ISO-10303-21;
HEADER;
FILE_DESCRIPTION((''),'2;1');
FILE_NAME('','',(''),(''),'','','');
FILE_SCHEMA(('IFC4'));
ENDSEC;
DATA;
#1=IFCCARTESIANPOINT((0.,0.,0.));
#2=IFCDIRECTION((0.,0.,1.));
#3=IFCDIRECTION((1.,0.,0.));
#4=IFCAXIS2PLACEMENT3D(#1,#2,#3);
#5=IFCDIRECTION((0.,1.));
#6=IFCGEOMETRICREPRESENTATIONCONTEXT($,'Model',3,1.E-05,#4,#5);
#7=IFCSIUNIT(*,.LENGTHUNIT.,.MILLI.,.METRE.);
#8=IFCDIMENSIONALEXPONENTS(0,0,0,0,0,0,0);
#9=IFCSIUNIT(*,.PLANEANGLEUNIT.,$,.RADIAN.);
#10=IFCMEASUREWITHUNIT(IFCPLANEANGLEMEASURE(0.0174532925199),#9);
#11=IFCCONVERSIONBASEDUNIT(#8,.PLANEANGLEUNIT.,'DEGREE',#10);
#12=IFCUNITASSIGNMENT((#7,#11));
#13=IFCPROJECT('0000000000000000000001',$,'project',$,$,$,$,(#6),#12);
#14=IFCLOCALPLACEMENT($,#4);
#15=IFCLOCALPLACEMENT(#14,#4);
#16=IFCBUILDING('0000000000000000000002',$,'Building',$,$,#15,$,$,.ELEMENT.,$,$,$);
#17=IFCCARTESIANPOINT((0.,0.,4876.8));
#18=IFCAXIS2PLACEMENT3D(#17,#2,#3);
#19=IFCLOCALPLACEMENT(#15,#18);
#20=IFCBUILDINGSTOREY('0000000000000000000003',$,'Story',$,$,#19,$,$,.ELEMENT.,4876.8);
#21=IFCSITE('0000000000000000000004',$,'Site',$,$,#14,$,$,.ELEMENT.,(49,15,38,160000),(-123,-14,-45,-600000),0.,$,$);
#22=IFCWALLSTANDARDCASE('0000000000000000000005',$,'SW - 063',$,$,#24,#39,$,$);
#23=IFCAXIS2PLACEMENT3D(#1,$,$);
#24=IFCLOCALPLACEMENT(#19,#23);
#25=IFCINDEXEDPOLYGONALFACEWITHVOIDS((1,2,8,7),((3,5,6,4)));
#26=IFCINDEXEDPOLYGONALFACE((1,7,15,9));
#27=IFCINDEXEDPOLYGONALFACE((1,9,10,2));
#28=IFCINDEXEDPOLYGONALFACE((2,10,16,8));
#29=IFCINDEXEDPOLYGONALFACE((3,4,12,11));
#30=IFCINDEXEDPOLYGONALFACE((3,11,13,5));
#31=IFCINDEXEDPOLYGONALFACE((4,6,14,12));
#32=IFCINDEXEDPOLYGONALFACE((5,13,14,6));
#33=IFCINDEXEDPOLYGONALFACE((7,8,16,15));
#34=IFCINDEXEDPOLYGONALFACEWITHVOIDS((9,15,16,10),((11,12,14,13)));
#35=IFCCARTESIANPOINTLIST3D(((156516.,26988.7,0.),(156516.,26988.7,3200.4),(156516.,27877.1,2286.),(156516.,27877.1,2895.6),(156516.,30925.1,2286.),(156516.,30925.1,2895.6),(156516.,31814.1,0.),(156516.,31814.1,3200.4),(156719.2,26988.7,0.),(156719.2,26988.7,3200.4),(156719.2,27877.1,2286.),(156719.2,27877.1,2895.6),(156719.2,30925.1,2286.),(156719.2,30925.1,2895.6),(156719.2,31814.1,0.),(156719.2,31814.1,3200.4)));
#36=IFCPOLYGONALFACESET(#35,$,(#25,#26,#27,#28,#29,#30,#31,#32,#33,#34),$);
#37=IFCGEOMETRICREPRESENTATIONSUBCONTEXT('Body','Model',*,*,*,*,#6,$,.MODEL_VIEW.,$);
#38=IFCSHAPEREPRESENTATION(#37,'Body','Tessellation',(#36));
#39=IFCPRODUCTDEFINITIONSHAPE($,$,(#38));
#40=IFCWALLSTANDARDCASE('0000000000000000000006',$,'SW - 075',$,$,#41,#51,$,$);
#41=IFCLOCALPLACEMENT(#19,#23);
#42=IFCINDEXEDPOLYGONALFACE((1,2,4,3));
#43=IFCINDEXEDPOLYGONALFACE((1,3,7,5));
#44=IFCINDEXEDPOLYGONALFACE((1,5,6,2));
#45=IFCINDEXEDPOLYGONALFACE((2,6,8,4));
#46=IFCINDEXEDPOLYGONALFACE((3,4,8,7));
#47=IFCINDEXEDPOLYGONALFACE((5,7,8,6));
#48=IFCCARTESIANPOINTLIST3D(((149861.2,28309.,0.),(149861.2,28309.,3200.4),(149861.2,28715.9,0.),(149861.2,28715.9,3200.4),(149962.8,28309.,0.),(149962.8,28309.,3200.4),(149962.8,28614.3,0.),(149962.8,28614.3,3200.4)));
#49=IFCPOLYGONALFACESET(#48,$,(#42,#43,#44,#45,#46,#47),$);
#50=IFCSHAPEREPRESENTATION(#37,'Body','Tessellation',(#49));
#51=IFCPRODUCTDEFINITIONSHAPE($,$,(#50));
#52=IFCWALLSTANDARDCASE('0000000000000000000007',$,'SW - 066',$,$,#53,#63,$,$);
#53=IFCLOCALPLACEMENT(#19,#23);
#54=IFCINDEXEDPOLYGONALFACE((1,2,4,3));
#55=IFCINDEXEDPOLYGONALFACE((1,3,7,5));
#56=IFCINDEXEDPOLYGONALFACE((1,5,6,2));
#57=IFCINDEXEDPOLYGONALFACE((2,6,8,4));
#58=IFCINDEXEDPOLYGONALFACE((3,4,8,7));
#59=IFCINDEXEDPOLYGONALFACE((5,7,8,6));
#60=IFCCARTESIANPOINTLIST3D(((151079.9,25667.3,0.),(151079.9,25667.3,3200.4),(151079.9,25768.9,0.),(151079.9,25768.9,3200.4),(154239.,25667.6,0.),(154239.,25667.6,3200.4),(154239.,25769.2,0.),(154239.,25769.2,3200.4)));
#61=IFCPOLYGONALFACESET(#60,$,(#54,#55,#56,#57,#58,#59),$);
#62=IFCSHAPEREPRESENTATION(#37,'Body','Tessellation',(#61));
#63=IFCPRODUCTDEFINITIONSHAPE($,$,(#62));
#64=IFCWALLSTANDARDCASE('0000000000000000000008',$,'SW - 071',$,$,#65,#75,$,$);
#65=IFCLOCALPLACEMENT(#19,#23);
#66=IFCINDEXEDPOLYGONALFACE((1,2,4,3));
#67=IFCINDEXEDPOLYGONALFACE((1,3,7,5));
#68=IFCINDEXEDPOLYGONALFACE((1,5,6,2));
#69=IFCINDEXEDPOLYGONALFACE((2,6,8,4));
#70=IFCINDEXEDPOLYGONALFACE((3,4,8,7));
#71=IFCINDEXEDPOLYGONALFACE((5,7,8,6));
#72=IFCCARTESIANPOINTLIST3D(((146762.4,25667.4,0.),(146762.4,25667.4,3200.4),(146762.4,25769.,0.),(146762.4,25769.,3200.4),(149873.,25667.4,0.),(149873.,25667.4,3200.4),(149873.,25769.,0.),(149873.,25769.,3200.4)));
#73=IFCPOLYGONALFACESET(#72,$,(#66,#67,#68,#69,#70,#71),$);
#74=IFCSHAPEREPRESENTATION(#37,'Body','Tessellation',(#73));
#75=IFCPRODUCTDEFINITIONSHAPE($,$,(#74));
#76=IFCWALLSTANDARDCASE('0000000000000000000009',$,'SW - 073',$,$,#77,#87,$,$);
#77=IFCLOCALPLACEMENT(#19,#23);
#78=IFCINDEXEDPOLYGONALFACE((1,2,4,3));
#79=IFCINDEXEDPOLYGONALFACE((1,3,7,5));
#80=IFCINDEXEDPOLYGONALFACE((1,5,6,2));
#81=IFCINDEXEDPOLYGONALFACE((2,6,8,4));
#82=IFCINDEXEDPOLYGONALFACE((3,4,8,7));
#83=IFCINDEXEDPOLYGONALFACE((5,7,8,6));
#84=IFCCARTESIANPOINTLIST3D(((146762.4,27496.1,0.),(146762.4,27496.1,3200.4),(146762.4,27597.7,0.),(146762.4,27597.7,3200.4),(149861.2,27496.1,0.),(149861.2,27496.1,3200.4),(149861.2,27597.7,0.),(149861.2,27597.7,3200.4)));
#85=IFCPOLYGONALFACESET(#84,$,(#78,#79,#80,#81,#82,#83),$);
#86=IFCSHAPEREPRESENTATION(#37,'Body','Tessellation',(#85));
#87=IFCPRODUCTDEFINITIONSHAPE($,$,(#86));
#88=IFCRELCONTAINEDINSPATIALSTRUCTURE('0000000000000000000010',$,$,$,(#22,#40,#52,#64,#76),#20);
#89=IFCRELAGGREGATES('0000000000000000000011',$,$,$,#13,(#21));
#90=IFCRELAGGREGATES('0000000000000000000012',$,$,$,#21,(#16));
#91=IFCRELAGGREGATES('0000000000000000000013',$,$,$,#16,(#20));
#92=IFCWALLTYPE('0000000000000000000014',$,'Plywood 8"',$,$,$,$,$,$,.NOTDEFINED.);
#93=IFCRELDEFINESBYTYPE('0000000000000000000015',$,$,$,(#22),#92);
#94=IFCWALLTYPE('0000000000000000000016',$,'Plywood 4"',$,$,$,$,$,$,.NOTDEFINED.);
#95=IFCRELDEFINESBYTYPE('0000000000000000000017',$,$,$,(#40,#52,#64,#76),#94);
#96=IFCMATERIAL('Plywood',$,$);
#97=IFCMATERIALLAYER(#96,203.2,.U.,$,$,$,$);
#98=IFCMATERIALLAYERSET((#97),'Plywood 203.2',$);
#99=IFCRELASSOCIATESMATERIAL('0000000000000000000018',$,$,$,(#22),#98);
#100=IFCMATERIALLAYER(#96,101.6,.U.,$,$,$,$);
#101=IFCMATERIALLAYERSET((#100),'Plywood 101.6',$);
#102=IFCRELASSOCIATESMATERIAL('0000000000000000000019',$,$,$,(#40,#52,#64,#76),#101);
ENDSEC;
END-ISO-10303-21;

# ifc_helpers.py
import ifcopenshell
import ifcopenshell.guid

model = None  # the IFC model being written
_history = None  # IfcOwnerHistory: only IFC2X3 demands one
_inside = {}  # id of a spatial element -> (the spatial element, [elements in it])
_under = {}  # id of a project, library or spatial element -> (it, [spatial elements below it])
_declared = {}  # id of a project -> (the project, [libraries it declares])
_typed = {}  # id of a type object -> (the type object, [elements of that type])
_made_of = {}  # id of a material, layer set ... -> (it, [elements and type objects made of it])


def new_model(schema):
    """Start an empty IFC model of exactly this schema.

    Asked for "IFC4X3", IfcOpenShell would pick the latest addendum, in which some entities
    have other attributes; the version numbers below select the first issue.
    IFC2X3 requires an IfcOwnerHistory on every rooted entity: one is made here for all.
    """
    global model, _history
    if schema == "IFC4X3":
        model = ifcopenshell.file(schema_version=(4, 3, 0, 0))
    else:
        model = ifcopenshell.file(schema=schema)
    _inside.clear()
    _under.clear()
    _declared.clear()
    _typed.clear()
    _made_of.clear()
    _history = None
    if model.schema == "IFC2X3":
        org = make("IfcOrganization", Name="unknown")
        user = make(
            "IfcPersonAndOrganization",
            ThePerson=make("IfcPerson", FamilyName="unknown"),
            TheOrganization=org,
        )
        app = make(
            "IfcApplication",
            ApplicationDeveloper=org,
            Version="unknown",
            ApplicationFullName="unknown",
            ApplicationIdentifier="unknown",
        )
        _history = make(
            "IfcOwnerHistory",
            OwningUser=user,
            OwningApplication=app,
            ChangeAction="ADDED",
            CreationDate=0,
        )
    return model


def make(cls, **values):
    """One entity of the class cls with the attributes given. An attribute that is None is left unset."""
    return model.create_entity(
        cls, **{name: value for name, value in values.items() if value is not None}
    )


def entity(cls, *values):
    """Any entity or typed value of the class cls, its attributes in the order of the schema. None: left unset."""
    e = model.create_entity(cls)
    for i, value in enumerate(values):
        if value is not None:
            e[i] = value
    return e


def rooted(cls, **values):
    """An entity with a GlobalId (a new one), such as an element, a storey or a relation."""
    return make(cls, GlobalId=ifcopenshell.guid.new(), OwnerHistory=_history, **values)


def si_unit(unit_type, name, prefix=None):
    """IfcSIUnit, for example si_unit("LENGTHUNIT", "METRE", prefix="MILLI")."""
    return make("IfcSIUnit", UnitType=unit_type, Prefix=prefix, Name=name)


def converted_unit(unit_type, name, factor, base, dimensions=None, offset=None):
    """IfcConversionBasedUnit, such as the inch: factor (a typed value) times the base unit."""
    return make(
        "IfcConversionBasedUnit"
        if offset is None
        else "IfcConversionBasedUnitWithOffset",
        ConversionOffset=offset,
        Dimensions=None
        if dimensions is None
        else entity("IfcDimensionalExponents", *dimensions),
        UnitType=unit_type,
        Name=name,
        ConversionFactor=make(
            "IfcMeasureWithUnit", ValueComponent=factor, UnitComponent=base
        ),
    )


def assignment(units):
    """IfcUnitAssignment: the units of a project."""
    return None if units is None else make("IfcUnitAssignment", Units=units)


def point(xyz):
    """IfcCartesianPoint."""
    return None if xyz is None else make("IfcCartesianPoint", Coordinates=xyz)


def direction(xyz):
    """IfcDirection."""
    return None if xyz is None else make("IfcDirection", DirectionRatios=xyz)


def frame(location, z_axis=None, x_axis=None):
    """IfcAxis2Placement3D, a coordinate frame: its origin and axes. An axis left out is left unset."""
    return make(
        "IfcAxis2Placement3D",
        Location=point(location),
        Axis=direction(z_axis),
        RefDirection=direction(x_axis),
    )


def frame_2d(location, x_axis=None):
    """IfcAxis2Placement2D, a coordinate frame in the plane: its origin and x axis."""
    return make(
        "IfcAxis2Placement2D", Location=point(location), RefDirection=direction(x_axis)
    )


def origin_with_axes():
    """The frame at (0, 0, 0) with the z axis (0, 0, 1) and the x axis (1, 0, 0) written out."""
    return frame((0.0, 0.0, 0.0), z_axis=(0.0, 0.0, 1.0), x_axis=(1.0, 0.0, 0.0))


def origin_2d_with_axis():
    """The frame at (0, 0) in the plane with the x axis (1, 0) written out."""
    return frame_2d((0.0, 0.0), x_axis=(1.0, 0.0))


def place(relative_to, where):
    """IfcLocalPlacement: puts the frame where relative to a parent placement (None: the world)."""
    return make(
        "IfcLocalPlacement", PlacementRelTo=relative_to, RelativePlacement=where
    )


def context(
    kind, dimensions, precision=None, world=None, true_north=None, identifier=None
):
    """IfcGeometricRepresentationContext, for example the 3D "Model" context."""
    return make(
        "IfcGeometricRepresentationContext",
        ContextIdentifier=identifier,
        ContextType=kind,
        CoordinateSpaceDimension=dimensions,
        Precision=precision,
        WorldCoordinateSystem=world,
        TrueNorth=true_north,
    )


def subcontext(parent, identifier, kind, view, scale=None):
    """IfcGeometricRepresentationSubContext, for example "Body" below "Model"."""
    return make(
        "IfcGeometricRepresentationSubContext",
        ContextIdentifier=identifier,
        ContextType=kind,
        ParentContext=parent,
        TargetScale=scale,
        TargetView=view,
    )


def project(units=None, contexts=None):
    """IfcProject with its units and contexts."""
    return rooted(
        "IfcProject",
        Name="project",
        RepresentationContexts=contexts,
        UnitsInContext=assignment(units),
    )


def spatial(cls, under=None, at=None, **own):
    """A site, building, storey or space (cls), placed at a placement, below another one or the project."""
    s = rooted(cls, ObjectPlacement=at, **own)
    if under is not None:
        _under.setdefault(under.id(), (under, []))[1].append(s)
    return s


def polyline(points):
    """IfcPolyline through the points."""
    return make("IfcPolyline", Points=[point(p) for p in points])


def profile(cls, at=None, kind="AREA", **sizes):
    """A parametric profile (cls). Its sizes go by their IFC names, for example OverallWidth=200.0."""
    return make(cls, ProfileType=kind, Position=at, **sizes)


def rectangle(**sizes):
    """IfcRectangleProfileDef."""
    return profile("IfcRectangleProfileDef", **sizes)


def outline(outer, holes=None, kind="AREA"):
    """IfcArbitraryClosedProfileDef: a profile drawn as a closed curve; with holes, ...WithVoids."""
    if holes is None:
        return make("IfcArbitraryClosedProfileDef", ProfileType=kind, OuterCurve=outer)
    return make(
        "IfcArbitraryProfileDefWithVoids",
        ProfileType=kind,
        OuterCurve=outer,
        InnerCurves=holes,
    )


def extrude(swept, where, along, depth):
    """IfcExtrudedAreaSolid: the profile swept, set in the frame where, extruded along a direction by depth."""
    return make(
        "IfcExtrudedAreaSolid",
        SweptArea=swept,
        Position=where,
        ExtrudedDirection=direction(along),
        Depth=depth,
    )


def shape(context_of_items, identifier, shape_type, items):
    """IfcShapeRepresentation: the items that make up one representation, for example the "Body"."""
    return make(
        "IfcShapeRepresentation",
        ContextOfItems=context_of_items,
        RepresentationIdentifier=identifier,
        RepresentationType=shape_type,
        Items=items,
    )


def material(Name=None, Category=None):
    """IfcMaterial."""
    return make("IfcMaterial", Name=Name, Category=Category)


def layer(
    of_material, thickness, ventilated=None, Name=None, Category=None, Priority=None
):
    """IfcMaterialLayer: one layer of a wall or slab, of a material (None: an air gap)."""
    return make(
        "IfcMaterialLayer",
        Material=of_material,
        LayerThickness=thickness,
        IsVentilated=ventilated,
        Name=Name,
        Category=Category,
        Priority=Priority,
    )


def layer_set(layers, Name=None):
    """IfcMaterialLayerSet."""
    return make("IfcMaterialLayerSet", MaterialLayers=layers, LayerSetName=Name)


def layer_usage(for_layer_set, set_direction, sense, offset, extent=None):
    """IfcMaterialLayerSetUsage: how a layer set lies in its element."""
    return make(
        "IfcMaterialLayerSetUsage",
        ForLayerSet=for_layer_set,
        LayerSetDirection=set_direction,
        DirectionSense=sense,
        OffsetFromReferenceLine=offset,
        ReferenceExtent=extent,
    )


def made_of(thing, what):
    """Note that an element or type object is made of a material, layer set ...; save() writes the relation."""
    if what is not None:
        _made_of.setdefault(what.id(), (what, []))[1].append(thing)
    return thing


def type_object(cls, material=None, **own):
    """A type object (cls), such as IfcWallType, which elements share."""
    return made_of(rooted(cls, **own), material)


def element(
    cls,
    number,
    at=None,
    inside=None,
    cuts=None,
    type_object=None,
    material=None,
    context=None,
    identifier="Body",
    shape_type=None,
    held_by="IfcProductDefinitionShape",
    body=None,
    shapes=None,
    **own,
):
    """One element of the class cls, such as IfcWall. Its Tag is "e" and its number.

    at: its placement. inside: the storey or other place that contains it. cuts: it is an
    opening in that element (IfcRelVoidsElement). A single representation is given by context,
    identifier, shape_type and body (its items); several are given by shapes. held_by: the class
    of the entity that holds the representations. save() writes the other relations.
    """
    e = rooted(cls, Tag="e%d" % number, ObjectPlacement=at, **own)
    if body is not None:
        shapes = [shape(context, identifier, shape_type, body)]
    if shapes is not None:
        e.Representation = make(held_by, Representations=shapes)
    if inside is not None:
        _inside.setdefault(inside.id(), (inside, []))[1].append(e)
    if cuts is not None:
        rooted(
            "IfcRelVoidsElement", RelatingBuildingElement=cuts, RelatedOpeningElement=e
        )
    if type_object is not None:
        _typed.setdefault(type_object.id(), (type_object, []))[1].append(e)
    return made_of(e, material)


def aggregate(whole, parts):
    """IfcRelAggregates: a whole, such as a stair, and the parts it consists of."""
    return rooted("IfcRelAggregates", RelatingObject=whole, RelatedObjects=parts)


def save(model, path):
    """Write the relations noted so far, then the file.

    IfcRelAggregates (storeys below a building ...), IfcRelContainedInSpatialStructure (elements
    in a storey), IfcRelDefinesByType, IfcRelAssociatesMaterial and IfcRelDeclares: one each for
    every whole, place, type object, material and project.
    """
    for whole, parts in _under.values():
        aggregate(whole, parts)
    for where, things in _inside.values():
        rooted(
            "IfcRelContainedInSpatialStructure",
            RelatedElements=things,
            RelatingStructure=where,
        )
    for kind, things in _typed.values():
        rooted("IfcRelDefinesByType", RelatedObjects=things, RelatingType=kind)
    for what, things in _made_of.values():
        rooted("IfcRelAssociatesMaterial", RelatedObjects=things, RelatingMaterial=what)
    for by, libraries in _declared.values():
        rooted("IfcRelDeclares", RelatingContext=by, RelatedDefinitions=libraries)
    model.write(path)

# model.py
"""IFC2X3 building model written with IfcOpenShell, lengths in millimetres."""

from ifc_helpers import new_model, entity, si_unit, converted_unit, direction, frame, origin_with_axes, origin_2d_with_axis, place, context, subcontext, project, spatial, polyline, rectangle, outline, extrude, material, layer, layer_set, layer_usage, type_object, element, save


model = new_model("IFC2X3")

# Units and contexts
model_context = context("Model", 3, precision=1e-05, world=origin_with_axes(), true_north=direction((0.0, 1.0)))
body_context = subcontext(model_context, "Body", "Model", "MODEL_VIEW")
ifc_project = project(units=[si_unit("LENGTHUNIT", "METRE", prefix="MILLI"), converted_unit("PLANEANGLEUNIT", "DEGREE", entity("IfcPlaneAngleMeasure", 0.0174532925199), si_unit("PLANEANGLEUNIT", "RADIAN"), dimensions=[0, 0, 0, 0, 0, 0, 0])], contexts=[model_context])

# Site, building, storey
site_placement = place(None, origin_with_axes())
site = spatial("IfcSite", under=ifc_project, at=site_placement, Name="Site", CompositionType="ELEMENT", RefLatitude=(49, 15, 38, 160000), RefLongitude=(-123, -14, -45, -600000), RefElevation=0.0)
building_placement = place(site_placement, origin_with_axes())
building = spatial("IfcBuilding", under=site, at=building_placement, Name="Building", CompositionType="ELEMENT")
storey_placement = place(building_placement, frame((0.0, 0.0, 4876.8), z_axis=(0.0, 0.0, 1.0), x_axis=(1.0, 0.0, 0.0)))
storey = spatial("IfcBuildingStorey", under=building, at=storey_placement, Name="Story", CompositionType="ELEMENT", Elevation=4876.8)

# Shared definitions
ifc_material_1 = material(Name="Plywood")
ifc_layer_1 = layer(ifc_material_1, 203.2, ventilated="UNKNOWN")
ifc_layer_set_1 = layer_set([ifc_layer_1], Name="Plywood 203.2")
wall_type_1 = type_object("IfcWallType", Name="Plywood 8\"", PredefinedType="NOTDEFINED")

# Wall, opening
ifc_layer_usage_1 = layer_usage(ifc_layer_set_1, "AXIS2", "NEGATIVE", 0.0)
wall_1_placement = place(storey_placement, frame((156516.0, 26988.7, 0.0), z_axis=(0.0, 0.0, 1.0), x_axis=(0.0, 1.0, 0.0)))
wall_1 = element("IfcWallStandardCase", 1, at=wall_1_placement, inside=storey, type_object=wall_type_1, material=ifc_layer_usage_1, Name="SW - 063", context=body_context, shape_type="SweptSolid", body=[
    extrude(outline(polyline([(0.0, -203.2), (4825.5, -203.2), (4825.5, 0.0), (0.0, 0.0), (0.0, -203.2)])), origin_with_axes(), (0.0, 0.0, 1.0), 3200.4),
])
opening_1_placement = place(wall_1_placement, frame((2412.5, 0.0, 2286.0), z_axis=(0.0, 0.0, 1.0), x_axis=(1.0, 0.0, 0.0)))
element("IfcOpeningElement", 2, at=opening_1_placement, cuts=wall_1, context=body_context, shape_type="SweptSolid", body=[
    extrude(rectangle(XDim=3048.0, YDim=609.6, at=origin_2d_with_axis()), frame((0.0, 203.2, 304.8), z_axis=(0.0, 1.0, 0.0), x_axis=(1.0, 0.0, 0.0)), (0.0, 0.0, -1.0), 609.6),
])

# Wall
ifc_layer_2 = layer(ifc_material_1, 101.6, ventilated="UNKNOWN")
ifc_layer_set_2 = layer_set([ifc_layer_2], Name="Plywood 101.6")
ifc_layer_usage_2 = layer_usage(ifc_layer_set_2, "AXIS2", "NEGATIVE", 0.0)
wall_type_2 = type_object("IfcWallType", Name="Plywood 4\"", PredefinedType="NOTDEFINED")
wall_2_placement = place(storey_placement, frame((149861.2, 28309.0, 0.0), z_axis=(0.0, 0.0, 1.0), x_axis=(0.0, 1.0, 0.0)))
element("IfcWallStandardCase", 3, at=wall_2_placement, inside=storey, type_object=wall_type_2, material=ifc_layer_usage_2, Name="SW - 075", context=body_context, shape_type="SweptSolid", body=[
    extrude(outline(polyline([(0.0, -101.6), (305.3, -101.6), (406.9, 0.0), (0.0, 0.0), (0.0, -101.6)])), origin_with_axes(), (0.0, 0.0, 1.0), 3200.4),
])

# Wall
ifc_layer_usage_3 = layer_usage(ifc_layer_set_2, "AXIS2", "NEGATIVE", 0.0)
wall_3_placement = place(storey_placement, frame((151079.9, 25768.9, 0.0), z_axis=(0.0, 0.0, 1.0), x_axis=(1.0, 0.000087, 0.0)))
element("IfcWallStandardCase", 4, at=wall_3_placement, inside=storey, type_object=wall_type_2, material=ifc_layer_usage_3, Name="SW - 066", context=body_context, shape_type="SweptSolid", body=[
    extrude(outline(polyline([(0.0, -101.6), (3159.2, -101.6), (3159.2, 0.0), (0.0, 0.0), (0.0, -101.6)])), origin_with_axes(), (0.0, 0.0, 1.0), 3200.4),
])

# Walls
ifc_layer_usage_4 = layer_usage(ifc_layer_set_2, "AXIS2", "NEGATIVE", 0.0)
wall_4_placement = place(storey_placement, frame((146762.4, 25769.0, 0.0), z_axis=(0.0, 0.0, 1.0), x_axis=(1.0, 0.0, 0.0)))
element("IfcWallStandardCase", 5, at=wall_4_placement, inside=storey, type_object=wall_type_2, material=ifc_layer_usage_4, Name="SW - 071", context=body_context, shape_type="SweptSolid", body=[
    extrude(outline(polyline([(0.0, -101.6), (3110.6, -101.6), (3110.6, 0.0), (0.0, 0.0), (0.0, -101.6)])), origin_with_axes(), (0.0, 0.0, 1.0), 3200.4),
])
ifc_layer_usage_5 = layer_usage(ifc_layer_set_2, "AXIS2", "NEGATIVE", 0.0)
wall_5_placement = place(storey_placement, frame((149861.2, 27496.1, 0.0), z_axis=(0.0, 0.0, 1.0), x_axis=(-1.0, 0.0, 0.0)))
element("IfcWallStandardCase", 6, at=wall_5_placement, inside=storey, type_object=wall_type_2, material=ifc_layer_usage_5, Name="SW - 073", context=body_context, shape_type="SweptSolid", body=[
    extrude(outline(polyline([(0.0, -101.6), (3098.8, -101.6), (3098.8, 0.0), (0.0, 0.0), (0.0, -101.6)])), origin_with_axes(), (0.0, 0.0, 1.0), 3200.4),
])

save(model, "model.ifc")
